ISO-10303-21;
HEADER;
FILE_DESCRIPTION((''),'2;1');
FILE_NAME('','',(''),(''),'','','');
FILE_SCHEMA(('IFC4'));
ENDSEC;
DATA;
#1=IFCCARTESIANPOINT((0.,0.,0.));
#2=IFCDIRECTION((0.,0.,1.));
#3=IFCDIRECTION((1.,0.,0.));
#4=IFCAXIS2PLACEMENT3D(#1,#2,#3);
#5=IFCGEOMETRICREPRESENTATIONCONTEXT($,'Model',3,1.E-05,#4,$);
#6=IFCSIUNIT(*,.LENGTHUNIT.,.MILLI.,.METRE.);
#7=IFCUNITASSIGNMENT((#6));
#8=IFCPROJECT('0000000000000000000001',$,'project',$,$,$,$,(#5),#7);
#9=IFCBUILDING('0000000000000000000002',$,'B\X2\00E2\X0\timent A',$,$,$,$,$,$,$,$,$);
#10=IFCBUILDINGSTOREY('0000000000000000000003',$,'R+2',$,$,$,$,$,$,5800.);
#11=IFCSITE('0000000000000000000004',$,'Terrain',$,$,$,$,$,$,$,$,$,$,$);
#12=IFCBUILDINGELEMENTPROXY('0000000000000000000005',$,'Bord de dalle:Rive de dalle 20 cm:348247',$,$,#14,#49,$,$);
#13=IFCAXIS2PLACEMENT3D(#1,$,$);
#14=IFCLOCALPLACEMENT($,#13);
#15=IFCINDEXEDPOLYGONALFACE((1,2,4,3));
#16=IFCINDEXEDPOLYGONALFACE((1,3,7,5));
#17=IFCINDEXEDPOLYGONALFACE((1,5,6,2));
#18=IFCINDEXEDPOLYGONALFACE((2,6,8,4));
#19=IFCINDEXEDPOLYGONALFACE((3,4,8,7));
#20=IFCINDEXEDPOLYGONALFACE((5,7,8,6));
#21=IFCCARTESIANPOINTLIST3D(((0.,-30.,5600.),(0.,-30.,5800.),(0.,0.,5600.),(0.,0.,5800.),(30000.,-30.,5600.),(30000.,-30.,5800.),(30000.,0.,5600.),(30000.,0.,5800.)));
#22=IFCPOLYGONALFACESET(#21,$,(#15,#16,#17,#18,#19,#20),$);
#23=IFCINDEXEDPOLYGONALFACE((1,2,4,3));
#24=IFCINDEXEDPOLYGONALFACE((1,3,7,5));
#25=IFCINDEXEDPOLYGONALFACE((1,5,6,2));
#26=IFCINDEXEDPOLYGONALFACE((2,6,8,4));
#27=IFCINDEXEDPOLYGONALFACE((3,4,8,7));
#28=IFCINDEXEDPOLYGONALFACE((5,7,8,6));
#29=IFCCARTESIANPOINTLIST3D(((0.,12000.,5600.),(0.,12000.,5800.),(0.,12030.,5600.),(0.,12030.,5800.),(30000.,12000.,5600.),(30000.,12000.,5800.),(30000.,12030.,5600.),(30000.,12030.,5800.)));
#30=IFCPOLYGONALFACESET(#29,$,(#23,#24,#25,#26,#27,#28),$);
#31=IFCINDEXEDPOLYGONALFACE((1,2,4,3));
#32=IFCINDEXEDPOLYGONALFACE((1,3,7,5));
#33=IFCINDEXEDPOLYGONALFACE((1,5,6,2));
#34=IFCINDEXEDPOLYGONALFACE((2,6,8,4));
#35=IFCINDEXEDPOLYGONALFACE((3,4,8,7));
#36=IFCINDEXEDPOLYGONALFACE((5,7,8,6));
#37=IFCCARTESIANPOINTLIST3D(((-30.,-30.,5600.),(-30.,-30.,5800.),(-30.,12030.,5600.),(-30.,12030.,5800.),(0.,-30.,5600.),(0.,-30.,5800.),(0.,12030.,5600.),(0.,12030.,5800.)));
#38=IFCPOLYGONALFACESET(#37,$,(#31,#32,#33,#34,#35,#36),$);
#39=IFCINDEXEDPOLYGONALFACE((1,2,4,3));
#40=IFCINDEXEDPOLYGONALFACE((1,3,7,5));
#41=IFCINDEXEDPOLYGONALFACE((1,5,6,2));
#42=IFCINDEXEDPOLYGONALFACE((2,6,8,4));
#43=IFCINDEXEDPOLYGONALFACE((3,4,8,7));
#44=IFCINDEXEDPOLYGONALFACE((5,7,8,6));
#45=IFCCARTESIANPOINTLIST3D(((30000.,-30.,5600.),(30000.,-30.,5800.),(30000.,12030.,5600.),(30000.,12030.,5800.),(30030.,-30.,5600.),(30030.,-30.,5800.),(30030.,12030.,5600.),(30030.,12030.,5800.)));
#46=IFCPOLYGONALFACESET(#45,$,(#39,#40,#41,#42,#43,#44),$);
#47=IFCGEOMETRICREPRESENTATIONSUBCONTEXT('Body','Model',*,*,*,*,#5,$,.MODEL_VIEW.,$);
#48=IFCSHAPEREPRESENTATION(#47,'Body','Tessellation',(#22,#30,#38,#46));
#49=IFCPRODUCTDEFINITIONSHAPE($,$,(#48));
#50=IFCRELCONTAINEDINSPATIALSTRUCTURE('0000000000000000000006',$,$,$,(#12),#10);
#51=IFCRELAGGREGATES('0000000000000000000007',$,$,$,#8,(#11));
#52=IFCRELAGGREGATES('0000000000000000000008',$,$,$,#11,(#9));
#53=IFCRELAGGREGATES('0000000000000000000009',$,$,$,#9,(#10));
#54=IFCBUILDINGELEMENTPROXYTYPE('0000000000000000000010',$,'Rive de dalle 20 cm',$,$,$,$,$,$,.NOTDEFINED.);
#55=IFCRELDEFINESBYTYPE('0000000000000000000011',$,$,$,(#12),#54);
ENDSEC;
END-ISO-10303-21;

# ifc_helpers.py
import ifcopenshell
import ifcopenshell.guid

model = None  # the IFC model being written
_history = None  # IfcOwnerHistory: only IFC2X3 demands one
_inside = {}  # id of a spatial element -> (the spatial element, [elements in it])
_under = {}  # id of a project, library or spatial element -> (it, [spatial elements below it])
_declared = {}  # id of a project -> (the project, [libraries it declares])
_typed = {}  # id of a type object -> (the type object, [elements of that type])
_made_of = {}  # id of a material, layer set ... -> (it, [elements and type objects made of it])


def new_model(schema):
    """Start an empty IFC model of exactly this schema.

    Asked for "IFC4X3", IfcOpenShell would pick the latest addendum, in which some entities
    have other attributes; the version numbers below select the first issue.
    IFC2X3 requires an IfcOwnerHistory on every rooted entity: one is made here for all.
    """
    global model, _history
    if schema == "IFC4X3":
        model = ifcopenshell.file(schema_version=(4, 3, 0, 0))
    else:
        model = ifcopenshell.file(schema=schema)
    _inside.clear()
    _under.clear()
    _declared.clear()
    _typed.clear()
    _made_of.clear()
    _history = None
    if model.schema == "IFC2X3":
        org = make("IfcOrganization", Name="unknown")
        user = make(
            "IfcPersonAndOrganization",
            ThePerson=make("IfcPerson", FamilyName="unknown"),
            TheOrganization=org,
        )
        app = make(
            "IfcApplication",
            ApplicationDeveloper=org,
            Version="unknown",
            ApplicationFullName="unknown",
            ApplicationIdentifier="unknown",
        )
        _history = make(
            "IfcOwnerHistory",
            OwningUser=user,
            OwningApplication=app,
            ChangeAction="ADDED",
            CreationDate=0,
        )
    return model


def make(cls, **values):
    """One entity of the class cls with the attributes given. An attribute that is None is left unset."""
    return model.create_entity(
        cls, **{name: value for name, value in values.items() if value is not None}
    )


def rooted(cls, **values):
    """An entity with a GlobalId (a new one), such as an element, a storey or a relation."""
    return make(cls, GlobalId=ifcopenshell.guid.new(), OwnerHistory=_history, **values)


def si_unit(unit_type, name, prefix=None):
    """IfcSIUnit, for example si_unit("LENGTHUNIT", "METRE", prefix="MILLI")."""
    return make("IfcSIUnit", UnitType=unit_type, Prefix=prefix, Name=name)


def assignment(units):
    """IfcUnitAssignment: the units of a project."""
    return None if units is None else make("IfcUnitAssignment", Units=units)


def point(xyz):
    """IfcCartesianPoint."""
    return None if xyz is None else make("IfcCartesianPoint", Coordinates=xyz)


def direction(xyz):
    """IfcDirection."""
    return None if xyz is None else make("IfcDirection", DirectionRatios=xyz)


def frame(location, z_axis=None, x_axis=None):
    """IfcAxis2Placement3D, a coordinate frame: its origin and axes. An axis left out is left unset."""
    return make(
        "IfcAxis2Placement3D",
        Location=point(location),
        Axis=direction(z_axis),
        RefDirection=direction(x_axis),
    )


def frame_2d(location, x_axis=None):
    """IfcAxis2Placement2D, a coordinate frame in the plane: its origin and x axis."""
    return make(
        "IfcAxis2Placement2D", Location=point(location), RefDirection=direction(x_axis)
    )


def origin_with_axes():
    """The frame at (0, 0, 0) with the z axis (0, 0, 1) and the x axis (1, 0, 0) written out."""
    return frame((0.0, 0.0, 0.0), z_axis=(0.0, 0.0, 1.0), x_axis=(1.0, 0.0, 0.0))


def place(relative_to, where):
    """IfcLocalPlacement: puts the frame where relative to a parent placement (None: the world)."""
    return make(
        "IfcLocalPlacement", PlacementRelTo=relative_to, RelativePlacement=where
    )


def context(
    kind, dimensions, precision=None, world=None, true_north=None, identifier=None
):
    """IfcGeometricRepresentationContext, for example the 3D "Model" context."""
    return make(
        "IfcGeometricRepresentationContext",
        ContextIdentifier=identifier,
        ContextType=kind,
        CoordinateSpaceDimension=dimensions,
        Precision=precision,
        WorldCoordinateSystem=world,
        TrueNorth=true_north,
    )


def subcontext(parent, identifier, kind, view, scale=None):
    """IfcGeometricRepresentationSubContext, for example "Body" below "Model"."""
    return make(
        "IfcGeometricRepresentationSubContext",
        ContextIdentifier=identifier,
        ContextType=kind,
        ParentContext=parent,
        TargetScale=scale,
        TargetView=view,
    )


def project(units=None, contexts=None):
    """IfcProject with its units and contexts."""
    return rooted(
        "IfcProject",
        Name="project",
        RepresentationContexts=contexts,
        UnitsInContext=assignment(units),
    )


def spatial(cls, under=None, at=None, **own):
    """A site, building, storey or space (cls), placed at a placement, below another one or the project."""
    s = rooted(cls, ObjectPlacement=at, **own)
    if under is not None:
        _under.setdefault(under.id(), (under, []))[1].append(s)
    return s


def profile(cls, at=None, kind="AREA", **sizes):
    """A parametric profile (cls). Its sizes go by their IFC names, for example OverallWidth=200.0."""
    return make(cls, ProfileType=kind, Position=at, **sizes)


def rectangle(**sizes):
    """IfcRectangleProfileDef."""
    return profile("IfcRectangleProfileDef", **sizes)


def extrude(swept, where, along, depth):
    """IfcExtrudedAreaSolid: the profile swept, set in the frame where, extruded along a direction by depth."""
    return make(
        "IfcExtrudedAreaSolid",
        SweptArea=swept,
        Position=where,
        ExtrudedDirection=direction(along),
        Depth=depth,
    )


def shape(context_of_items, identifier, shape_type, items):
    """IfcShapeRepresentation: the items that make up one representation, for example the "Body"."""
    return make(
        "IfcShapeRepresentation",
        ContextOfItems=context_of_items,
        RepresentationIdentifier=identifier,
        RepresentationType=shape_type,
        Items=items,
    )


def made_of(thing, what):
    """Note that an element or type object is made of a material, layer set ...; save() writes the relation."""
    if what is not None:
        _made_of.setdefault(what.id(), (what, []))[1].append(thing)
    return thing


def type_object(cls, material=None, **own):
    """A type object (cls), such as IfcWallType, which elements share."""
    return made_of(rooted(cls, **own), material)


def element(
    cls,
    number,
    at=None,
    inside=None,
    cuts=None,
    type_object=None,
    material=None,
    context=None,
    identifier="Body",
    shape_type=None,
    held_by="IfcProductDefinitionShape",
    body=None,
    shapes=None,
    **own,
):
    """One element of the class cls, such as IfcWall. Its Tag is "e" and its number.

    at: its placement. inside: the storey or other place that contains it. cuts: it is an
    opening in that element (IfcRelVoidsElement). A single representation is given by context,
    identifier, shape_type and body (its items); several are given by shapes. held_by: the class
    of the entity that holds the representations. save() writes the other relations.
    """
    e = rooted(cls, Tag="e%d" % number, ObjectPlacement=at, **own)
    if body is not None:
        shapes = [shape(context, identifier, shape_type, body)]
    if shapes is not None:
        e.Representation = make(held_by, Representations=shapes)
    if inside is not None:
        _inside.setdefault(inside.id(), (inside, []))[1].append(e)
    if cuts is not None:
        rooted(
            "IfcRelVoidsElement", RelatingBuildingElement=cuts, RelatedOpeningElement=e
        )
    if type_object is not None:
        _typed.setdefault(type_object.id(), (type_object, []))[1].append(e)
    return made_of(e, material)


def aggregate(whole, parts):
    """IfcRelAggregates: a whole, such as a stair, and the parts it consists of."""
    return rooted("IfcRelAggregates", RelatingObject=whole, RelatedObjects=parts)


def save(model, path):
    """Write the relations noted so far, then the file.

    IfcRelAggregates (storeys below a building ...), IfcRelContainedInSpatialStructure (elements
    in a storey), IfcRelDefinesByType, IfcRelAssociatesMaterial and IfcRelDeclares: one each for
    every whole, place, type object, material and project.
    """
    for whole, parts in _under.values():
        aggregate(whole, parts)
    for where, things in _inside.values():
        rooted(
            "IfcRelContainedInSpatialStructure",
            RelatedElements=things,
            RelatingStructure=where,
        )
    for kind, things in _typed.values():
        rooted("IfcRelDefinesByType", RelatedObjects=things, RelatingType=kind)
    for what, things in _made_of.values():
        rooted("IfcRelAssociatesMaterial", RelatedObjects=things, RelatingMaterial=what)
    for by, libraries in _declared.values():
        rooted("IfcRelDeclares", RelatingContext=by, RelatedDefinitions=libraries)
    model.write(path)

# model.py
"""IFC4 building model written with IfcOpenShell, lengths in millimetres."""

from ifc_helpers import new_model, si_unit, frame, frame_2d, origin_with_axes, place, context, subcontext, project, spatial, rectangle, extrude, type_object, element, save


model = new_model("IFC4")

# Units and contexts
model_context = context("Model", 3, precision=1e-05, world=origin_with_axes())
body_context = subcontext(model_context, "Body", "Model", "MODEL_VIEW")
ifc_project = project(units=[si_unit("LENGTHUNIT", "METRE", prefix="MILLI")], contexts=[model_context])

# Site, building, storey
site = spatial("IfcSite", under=ifc_project, Name="Terrain")
building = spatial("IfcBuilding", under=site, Name="Bâtiment A")
storey = spatial("IfcBuildingStorey", under=building, Name="R+2", Elevation=5800.0)

# Building element proxy
building_element_proxy_type = type_object("IfcBuildingElementProxyType", Name="Rive de dalle 20 cm", PredefinedType="NOTDEFINED")
proxy_placement = place(None, origin_with_axes())
element("IfcBuildingElementProxy", 1, at=proxy_placement, inside=storey, type_object=building_element_proxy_type, Name="Bord de dalle:Rive de dalle 20 cm:348247", context=body_context, shape_type="SweptSolid", body=[
    extrude(rectangle(XDim=30000.0, YDim=30.0, at=frame_2d((15000.0, -15.0))), frame((0.0, 0.0, 5600.0), z_axis=(0.0, 0.0, 1.0), x_axis=(1.0, 0.0, 0.0)), (0.0, 0.0, 1.0), 200.0),
    extrude(rectangle(XDim=30000.0, YDim=30.0, at=frame_2d((15000.0, 12015.0))), frame((0.0, 0.0, 5600.0), z_axis=(0.0, 0.0, 1.0), x_axis=(1.0, 0.0, 0.0)), (0.0, 0.0, 1.0), 200.0),
    extrude(rectangle(XDim=30.0, YDim=12060.0, at=frame_2d((-15.0, 6000.0))), frame((0.0, 0.0, 5600.0), z_axis=(0.0, 0.0, 1.0), x_axis=(1.0, 0.0, 0.0)), (0.0, 0.0, 1.0), 200.0),
    extrude(rectangle(XDim=30.0, YDim=12060.0, at=frame_2d((30015.0, 6000.0))), frame((0.0, 0.0, 5600.0), z_axis=(0.0, 0.0, 1.0), x_axis=(1.0, 0.0, 0.0)), (0.0, 0.0, 1.0), 200.0),
])

save(model, "model.ifc")
